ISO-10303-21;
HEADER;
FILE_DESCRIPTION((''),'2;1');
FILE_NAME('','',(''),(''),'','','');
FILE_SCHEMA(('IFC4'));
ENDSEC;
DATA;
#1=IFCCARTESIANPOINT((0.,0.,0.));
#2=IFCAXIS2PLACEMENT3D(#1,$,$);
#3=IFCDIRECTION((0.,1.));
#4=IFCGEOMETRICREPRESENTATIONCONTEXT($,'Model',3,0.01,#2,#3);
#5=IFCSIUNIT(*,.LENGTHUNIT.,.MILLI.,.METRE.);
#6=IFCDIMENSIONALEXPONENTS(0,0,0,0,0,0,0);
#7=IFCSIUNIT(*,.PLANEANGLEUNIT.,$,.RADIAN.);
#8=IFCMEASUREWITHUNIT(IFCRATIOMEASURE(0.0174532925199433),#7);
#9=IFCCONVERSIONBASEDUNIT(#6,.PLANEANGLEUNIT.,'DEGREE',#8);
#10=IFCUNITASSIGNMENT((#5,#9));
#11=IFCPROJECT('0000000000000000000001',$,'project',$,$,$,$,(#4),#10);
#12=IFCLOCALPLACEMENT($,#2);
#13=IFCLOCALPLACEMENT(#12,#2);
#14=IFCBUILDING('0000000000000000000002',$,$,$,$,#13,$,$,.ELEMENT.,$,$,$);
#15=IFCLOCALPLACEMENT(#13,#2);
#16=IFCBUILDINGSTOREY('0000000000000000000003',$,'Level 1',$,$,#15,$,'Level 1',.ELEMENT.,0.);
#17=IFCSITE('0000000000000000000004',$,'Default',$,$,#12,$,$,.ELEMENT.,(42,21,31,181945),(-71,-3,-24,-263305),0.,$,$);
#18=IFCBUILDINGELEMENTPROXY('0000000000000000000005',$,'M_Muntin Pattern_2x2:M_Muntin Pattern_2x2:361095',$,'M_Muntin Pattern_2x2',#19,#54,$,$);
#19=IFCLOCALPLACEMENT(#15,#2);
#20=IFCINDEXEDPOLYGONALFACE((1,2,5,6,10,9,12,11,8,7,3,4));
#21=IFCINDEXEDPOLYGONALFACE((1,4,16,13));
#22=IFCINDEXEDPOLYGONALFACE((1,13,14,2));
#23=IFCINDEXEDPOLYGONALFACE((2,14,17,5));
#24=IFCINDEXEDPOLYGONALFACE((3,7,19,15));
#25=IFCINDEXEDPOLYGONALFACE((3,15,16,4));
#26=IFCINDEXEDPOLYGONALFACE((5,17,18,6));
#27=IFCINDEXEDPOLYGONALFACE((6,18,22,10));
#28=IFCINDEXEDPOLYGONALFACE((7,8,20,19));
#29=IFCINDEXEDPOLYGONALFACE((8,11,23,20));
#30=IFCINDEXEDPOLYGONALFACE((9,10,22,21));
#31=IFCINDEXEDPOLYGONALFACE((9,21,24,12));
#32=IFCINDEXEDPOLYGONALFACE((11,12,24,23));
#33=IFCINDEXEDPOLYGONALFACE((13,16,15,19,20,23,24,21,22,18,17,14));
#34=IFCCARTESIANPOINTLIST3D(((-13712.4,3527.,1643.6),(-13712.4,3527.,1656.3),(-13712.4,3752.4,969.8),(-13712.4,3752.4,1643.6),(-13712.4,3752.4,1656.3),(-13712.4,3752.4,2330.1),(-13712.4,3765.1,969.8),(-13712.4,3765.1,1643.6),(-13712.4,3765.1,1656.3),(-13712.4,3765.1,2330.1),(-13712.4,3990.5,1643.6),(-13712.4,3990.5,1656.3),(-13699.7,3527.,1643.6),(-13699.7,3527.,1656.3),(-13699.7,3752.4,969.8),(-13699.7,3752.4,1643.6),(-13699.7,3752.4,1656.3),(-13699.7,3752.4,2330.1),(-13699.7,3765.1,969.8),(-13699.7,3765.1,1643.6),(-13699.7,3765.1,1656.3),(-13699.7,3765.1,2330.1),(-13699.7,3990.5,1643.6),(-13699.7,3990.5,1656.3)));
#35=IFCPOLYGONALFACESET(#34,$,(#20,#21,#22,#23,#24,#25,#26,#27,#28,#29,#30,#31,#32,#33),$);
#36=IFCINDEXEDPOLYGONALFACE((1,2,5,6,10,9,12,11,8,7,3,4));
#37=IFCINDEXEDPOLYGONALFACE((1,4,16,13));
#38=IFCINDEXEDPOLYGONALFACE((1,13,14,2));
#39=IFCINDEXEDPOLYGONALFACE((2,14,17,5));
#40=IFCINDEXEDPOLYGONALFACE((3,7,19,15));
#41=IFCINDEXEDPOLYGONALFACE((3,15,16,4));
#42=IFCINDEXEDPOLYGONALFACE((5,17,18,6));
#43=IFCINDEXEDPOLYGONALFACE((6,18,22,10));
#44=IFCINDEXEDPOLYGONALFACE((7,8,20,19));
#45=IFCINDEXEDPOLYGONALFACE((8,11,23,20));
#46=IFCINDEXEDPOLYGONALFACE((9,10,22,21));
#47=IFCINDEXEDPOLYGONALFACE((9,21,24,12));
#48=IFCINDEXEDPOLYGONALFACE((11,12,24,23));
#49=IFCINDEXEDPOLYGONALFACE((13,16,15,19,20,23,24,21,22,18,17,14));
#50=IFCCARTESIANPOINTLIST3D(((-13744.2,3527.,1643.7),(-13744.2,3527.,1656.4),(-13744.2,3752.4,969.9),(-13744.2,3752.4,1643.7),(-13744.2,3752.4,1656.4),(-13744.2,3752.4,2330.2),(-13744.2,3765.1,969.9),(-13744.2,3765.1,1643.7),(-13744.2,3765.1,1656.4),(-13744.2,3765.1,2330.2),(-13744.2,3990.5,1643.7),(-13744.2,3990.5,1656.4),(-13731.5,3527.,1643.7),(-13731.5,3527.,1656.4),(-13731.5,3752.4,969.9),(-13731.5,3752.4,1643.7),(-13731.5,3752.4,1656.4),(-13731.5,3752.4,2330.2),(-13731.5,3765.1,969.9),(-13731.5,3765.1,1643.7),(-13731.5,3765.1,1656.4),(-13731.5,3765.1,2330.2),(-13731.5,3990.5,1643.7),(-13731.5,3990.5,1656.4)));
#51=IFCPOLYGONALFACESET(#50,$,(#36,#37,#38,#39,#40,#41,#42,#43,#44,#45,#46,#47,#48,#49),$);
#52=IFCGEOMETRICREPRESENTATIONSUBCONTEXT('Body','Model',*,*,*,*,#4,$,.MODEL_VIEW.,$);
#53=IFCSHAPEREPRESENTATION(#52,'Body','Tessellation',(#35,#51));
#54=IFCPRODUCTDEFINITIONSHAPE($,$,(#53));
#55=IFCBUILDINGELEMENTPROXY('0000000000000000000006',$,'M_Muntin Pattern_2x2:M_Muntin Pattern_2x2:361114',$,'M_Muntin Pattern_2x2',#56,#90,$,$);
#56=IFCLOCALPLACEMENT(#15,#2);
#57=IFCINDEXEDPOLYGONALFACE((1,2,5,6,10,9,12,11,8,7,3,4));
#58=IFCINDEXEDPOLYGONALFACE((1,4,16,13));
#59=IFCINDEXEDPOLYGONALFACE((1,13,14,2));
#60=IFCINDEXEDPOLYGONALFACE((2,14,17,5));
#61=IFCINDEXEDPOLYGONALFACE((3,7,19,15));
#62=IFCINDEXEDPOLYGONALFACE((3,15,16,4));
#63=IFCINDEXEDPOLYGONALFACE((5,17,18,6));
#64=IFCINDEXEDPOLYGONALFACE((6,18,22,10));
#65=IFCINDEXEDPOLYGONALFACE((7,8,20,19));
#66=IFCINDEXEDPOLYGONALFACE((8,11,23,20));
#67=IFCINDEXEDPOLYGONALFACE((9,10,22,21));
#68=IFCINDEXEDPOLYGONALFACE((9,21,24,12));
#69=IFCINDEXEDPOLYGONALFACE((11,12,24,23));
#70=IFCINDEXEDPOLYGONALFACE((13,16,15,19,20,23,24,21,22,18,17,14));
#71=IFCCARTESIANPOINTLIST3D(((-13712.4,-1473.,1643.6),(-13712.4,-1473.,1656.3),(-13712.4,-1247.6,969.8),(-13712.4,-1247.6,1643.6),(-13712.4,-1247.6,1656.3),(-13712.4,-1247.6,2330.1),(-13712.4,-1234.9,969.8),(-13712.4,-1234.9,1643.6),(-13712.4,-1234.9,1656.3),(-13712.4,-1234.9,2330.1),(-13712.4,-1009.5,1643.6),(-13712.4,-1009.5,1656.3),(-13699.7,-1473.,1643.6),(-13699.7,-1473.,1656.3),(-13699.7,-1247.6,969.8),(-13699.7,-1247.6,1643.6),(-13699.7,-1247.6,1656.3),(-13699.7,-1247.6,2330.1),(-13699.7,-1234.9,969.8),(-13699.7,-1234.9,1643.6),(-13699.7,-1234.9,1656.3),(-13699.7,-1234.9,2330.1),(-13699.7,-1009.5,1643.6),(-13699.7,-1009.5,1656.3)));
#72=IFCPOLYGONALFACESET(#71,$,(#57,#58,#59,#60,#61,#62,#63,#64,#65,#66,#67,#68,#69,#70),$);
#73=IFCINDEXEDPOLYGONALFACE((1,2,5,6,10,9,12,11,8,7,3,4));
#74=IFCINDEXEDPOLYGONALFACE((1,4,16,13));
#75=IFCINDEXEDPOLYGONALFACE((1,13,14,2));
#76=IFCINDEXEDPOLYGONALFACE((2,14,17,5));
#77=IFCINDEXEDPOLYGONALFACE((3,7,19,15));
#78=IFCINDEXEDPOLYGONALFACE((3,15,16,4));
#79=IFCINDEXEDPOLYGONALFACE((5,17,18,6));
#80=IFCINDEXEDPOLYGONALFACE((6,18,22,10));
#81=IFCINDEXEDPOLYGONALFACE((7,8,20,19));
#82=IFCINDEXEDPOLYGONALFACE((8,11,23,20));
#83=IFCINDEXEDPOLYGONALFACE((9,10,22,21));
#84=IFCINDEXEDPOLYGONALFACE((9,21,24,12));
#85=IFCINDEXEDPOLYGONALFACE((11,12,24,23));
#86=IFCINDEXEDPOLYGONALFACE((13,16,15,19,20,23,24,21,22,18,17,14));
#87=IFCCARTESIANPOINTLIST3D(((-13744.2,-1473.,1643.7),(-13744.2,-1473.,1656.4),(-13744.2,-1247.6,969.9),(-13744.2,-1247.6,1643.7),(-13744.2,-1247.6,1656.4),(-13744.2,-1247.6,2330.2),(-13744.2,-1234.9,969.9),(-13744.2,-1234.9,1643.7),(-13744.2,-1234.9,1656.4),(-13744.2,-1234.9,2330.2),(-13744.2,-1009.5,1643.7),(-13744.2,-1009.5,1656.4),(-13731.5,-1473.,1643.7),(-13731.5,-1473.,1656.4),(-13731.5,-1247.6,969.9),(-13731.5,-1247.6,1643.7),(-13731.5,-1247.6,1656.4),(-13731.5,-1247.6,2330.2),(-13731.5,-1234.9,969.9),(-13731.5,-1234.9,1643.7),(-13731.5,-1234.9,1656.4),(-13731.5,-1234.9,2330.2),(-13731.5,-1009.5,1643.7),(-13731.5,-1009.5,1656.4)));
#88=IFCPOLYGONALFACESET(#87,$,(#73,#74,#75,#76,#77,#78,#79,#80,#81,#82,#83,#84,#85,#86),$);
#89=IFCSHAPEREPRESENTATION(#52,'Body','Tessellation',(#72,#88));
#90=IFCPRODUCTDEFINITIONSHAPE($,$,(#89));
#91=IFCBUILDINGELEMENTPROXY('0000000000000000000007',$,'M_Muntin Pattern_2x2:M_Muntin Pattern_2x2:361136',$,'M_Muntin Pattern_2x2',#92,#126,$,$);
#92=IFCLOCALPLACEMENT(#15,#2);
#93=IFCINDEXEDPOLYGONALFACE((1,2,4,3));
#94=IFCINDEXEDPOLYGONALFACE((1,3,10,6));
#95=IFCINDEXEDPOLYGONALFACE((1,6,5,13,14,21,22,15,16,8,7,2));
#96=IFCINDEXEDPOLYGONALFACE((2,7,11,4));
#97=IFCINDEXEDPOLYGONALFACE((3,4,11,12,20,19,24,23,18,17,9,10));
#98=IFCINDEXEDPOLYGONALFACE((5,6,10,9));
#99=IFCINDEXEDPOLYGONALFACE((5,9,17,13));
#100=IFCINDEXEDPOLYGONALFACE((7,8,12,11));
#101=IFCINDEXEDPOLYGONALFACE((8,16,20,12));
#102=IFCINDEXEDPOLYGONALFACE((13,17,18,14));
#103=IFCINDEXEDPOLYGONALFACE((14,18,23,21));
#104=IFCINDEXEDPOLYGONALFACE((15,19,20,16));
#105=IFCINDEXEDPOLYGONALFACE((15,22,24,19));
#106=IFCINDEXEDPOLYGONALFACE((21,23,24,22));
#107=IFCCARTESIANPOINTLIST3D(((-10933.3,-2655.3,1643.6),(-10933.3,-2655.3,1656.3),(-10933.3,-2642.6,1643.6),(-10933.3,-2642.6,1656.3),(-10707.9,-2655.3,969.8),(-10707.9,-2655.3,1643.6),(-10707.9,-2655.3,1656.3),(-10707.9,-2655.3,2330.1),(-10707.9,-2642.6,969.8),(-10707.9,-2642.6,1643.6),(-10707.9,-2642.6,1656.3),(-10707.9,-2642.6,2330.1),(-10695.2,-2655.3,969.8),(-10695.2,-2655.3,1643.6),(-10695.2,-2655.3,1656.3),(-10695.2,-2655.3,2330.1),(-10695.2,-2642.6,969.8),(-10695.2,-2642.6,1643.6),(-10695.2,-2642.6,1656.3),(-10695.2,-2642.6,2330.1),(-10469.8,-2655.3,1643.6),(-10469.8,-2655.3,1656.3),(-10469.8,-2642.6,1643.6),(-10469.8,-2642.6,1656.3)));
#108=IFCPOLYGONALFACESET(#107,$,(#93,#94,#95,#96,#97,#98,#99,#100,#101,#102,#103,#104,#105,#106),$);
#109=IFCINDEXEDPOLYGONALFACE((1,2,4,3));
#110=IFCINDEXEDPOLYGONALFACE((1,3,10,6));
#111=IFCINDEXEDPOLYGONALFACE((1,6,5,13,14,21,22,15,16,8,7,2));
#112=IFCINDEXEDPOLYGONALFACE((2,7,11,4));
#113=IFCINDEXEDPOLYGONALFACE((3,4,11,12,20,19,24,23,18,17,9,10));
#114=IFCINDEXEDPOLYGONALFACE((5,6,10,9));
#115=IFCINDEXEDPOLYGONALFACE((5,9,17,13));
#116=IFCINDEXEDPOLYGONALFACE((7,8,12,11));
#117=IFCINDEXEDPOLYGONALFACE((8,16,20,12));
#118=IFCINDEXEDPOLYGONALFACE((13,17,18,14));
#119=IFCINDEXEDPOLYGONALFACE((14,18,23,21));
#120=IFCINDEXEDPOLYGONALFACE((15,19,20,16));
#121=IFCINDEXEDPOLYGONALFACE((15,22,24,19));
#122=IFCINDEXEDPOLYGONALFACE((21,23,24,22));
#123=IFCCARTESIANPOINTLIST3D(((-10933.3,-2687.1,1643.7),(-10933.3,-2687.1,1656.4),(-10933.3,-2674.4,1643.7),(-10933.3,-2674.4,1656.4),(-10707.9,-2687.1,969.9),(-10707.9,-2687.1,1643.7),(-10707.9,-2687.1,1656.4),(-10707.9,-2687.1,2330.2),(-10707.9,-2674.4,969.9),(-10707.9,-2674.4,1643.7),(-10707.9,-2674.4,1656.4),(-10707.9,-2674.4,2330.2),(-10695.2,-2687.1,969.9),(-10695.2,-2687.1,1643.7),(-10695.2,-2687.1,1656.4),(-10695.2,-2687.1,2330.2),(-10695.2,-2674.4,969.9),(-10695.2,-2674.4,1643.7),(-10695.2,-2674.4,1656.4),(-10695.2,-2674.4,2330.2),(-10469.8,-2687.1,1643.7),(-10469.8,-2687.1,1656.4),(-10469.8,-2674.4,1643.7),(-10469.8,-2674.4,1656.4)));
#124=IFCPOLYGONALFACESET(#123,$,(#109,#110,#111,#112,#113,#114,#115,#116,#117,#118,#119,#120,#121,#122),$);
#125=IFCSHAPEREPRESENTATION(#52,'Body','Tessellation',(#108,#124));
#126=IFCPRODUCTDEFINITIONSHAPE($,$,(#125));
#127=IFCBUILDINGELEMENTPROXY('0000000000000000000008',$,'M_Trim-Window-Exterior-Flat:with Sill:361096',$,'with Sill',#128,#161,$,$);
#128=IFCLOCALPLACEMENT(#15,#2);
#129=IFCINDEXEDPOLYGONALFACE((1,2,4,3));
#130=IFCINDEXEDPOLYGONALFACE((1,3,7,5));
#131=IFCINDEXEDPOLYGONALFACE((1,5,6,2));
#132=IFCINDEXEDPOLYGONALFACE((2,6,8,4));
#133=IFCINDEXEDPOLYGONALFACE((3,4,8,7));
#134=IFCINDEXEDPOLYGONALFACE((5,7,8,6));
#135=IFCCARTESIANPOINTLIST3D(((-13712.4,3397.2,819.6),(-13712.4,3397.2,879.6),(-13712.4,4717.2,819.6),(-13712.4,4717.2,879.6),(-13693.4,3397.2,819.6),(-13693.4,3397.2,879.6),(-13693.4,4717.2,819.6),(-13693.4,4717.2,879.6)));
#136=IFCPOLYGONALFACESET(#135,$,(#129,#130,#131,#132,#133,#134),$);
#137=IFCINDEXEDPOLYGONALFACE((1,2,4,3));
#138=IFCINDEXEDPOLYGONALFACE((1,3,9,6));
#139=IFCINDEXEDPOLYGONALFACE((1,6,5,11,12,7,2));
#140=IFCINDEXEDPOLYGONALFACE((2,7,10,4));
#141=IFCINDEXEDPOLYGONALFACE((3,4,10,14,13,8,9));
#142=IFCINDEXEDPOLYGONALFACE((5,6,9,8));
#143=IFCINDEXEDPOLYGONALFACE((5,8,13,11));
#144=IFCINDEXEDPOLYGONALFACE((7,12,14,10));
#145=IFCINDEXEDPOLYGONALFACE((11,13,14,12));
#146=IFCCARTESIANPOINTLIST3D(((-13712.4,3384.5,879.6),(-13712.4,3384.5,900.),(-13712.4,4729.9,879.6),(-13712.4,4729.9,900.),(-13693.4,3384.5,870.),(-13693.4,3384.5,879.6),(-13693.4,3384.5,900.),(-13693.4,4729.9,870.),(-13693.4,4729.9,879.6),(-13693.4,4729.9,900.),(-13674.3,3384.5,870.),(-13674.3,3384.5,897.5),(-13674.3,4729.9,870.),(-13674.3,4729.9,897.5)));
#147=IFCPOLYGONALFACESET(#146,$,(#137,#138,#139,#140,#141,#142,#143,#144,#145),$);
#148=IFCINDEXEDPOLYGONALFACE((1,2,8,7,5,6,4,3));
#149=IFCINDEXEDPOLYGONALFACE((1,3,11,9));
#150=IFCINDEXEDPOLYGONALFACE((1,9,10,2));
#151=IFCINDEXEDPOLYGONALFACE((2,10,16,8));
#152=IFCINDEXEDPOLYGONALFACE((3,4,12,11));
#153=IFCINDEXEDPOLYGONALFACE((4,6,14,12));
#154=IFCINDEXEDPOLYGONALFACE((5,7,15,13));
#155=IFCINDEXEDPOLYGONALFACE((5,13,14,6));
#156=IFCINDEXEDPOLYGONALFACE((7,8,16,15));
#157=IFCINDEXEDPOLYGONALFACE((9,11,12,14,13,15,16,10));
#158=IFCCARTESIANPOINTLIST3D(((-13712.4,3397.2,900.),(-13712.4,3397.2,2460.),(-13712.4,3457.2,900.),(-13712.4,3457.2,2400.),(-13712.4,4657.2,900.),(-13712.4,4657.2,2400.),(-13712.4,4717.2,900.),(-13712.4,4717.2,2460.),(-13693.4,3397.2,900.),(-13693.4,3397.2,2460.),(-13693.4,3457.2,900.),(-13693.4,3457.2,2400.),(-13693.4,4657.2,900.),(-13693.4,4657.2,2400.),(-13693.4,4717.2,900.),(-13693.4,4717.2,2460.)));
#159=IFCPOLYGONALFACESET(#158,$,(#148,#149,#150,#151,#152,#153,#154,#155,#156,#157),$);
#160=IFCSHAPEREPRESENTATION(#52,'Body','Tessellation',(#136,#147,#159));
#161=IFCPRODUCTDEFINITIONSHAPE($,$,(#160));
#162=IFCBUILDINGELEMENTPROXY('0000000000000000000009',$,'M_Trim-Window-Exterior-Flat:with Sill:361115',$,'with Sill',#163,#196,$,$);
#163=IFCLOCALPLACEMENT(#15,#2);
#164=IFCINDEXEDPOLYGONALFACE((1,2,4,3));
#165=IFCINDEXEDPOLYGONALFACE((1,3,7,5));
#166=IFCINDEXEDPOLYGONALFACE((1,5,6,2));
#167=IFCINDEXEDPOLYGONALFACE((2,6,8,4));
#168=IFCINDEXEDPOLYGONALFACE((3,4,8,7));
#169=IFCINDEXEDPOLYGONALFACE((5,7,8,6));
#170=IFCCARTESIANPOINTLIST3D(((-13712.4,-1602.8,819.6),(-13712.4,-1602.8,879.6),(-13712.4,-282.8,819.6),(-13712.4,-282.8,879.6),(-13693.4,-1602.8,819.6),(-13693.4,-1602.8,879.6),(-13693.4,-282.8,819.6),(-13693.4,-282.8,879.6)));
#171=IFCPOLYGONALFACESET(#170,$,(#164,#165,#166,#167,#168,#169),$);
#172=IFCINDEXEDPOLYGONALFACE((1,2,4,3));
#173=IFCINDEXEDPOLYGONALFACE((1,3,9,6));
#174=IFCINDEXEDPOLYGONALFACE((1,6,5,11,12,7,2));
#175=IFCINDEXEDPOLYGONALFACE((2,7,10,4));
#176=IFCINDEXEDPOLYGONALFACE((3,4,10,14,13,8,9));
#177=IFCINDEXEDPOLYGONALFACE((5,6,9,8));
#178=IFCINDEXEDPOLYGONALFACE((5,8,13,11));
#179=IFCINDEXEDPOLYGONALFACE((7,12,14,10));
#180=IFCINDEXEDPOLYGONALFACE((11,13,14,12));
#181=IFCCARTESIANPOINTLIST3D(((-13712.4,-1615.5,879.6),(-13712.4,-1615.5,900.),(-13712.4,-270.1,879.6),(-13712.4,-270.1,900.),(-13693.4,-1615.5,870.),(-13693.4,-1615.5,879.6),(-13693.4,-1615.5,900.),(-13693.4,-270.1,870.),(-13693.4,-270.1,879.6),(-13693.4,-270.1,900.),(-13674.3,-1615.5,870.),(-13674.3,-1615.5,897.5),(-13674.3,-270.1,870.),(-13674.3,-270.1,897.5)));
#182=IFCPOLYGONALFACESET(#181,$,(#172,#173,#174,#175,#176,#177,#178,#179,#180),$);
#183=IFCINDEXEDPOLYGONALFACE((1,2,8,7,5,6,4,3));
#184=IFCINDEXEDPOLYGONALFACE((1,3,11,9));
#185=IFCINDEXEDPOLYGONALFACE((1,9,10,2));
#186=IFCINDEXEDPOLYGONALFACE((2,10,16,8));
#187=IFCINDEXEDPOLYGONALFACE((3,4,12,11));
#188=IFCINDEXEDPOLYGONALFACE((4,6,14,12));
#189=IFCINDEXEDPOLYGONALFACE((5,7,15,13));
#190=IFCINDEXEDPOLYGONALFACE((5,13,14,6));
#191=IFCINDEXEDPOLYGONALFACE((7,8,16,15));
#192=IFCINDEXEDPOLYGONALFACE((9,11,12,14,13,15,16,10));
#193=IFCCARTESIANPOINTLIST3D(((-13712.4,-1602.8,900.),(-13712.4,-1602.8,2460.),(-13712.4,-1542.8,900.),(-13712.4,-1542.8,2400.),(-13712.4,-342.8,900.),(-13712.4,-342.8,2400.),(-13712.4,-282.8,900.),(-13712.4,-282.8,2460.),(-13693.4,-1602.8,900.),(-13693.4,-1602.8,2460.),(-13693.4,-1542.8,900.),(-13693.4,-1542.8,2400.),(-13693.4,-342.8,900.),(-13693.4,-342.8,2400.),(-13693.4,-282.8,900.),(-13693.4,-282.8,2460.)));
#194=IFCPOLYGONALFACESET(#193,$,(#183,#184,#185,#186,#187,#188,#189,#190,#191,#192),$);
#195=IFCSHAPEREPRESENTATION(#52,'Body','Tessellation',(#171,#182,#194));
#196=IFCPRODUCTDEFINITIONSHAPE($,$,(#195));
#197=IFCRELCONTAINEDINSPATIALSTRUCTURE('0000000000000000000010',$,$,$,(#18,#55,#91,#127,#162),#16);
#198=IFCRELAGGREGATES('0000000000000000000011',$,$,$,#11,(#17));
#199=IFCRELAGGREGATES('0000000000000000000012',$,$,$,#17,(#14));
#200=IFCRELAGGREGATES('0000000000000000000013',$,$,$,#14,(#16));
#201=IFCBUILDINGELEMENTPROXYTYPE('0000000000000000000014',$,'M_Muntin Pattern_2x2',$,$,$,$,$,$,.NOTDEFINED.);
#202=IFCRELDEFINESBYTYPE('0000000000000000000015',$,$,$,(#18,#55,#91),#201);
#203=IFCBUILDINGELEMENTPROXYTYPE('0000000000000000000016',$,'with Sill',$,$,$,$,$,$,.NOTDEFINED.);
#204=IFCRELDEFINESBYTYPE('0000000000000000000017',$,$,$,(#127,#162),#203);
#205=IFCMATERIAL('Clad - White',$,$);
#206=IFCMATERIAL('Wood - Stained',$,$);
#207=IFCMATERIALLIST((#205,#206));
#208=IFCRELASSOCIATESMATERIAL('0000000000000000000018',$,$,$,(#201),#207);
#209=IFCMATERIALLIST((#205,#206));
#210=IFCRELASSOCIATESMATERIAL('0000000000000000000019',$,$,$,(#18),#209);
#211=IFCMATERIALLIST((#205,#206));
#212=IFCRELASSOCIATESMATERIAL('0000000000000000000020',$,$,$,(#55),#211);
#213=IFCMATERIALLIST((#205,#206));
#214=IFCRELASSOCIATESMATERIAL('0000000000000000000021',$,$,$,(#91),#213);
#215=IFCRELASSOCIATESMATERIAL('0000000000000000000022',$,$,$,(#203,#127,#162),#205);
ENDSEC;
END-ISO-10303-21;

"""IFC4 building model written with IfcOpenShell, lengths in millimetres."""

from ifc_helpers import new_model, entity, si_unit, converted_unit, direction, frame, frame_2d, origin, place, context, subcontext, project, spatial, polyline, rectangle, outline, extrude, source, transform, mapped, material, material_list, type_object, type_shapes, element, save


model = new_model("IFC4")

# Units and contexts
model_context = context("Model", 3, precision=0.01, world=origin(), true_north=direction((0.0, 1.0)))
body_context = subcontext(model_context, "Body", "Model", "MODEL_VIEW")
ifc_project = project(units=[si_unit("LENGTHUNIT", "METRE", prefix="MILLI"), converted_unit("PLANEANGLEUNIT", "DEGREE", entity("IfcRatioMeasure", 0.0174532925199433), si_unit("PLANEANGLEUNIT", "RADIAN"), dimensions=[0, 0, 0, 0, 0, 0, 0])], contexts=[model_context])

# Site, building, storey
site_placement = place(None, origin())
site = spatial("IfcSite", under=ifc_project, at=site_placement, Name="Default", CompositionType="ELEMENT", RefLatitude=(42, 21, 31, 181945), RefLongitude=(-71, -3, -24, -263305), RefElevation=0.0)
building_placement = place(site_placement, origin())
building = spatial("IfcBuilding", under=site, at=building_placement, CompositionType="ELEMENT")
storey_placement = place(building_placement, origin())
storey = spatial("IfcBuildingStorey", under=building, at=storey_placement, Name="Level 1", LongName="Level 1", CompositionType="ELEMENT", Elevation=0.0)

# Building element proxies
ifc_material_1 = material(Name="Clad - White")
ifc_material_2 = material(Name="Wood - Stained")
ifc_material_list_1 = material_list([ifc_material_1, ifc_material_2])
ifc_material_list_2 = material_list([ifc_material_1, ifc_material_2])
building_element_proxy_type_1 = type_object("IfcBuildingElementProxyType", Name="M_Muntin Pattern_2x2", PredefinedType="NOTDEFINED", material=ifc_material_list_2)
shared_shape_1 = source(origin(), body_context, "Body", "SweptSolid", [
    extrude(outline(polyline([(6.4, -6.4), (680.1, -6.4), (680.1, 6.3), (6.4, 6.3), (6.4, 231.7), (-6.3, 231.7), (-6.3, 6.3), (-680.2, 6.3), (-680.2, -6.4), (-6.3, -6.4), (-6.3, -231.7), (6.4, -231.7), (6.4, -6.4)])), frame((0.0, -22.2, 680.1), z_axis=(0.0, 1.0, 0.0), x_axis=(0.0, 0.0, 1.0)), (0.0, 0.0, 1.0), 12.7),
    extrude(outline(polyline([(6.4, -6.4), (680.1, -6.4), (680.1, 6.3), (6.4, 6.3), (6.4, 231.7), (-6.3, 231.7), (-6.3, 6.3), (-680.2, 6.3), (-680.2, -6.4), (-6.3, -6.4), (-6.3, -231.7), (6.4, -231.7), (6.4, -6.4)])), frame((0.0, 9.5, 680.2), z_axis=(0.0, 1.0, 0.0), x_axis=(0.0, 0.0, 1.0)), (0.0, 0.0, 1.0), 12.7),
])
type_shapes(building_element_proxy_type_1, [shared_shape_1])
proxy_1_placement = place(storey_placement, frame((-13722.0, 3758.7, 969.9), z_axis=(0.0, 0.0, 1.0), x_axis=(0.0, 1.0, 0.0)))
element("IfcBuildingElementProxy", 1, at=proxy_1_placement, inside=storey, type_object=building_element_proxy_type_1, material=ifc_material_list_1, Name="M_Muntin Pattern_2x2:M_Muntin Pattern_2x2:361095", ObjectType="M_Muntin Pattern_2x2", context=body_context, shape_type="MappedRepresentation", body=[
    mapped(shared_shape_1, transform((0.0, 0.0, 0.0), scale=1.0)),
])
ifc_material_list_3 = material_list([ifc_material_1, ifc_material_2])
proxy_2_placement = place(storey_placement, frame((-13722.0, -1241.3, 969.9), z_axis=(0.0, 0.0, 1.0), x_axis=(0.0, 1.0, 0.0)))
element("IfcBuildingElementProxy", 2, at=proxy_2_placement, inside=storey, type_object=building_element_proxy_type_1, material=ifc_material_list_3, Name="M_Muntin Pattern_2x2:M_Muntin Pattern_2x2:361114", ObjectType="M_Muntin Pattern_2x2", context=body_context, shape_type="MappedRepresentation", body=[
    mapped(shared_shape_1, transform((0.0, 0.0, 0.0), scale=1.0)),
])
ifc_material_list_4 = material_list([ifc_material_1, ifc_material_2])
proxy_3_placement = place(storey_placement, frame((-10701.5, -2664.9, 969.9), z_axis=(0.0, 0.0, 1.0), x_axis=(-1.0, 0.0, 0.0)))
element("IfcBuildingElementProxy", 3, at=proxy_3_placement, inside=storey, type_object=building_element_proxy_type_1, material=ifc_material_list_4, Name="M_Muntin Pattern_2x2:M_Muntin Pattern_2x2:361136", ObjectType="M_Muntin Pattern_2x2", context=body_context, shape_type="MappedRepresentation", body=[
    mapped(shared_shape_1, transform((0.0, 0.0, 0.0), scale=1.0)),
])
building_element_proxy_type_2 = type_object("IfcBuildingElementProxyType", Name="with Sill", PredefinedType="NOTDEFINED", material=ifc_material_1)
shared_shape_2 = source(origin(), body_context, "Body", "SweptSolid", [
    extrude(rectangle(XDim=1320.0, YDim=60.0, at=frame_2d((0.0, 0.0), x_axis=(1.0, 0.0))), frame((0.0, -1550.4, 0.0), z_axis=(0.0, 0.0, 1.0), x_axis=(-1.0, 0.0, 0.0)), (0.0, 0.0, 1.0), 19.1),
    extrude(outline(polyline([(-19.0, -15.2), (0.0, -15.2), (0.0, -5.7), (19.0, -5.7), (19.0, 14.8), (0.0, 14.8), (-19.0, 12.3), (-19.0, -15.2)])), frame((-672.7, -1514.8, 19.0), z_axis=(1.0, 0.0, 0.0), x_axis=(0.0, 0.0, -1.0)), (0.0, 0.0, 1.0), 1345.4),
    extrude(outline(polyline([(-795.0, -660.0), (765.0, -660.0), (765.0, -600.0), (-735.0, -600.0), (-735.0, 600.0), (765.0, 600.0), (765.0, 660.0), (-795.0, 660.0), (-795.0, -660.0)])), frame((0.0, -735.0, 0.0), z_axis=(0.0, 0.0, 1.0), x_axis=(0.0, -1.0, 0.0)), (0.0, 0.0, 1.0), 19.1),
])
type_shapes(building_element_proxy_type_2, [shared_shape_2])
for number, where, z_axis, x_axis, name in (
    (4, (-13712.4, 4057.2, 2400.0), (1.0, 0.0, 0.0), (0.0, 1.0, 0.0), "M_Trim-Window-Exterior-Flat:with Sill:361096"),
    (5, (-13712.4, -942.8, 2400.0), (1.0, 0.0, 0.0), (0.0, 1.0, 0.0), "M_Trim-Window-Exterior-Flat:with Sill:361115"),
):
    element("IfcBuildingElementProxy", number, at=place(storey_placement, frame(where, z_axis=z_axis, x_axis=x_axis)), inside=storey, type_object=building_element_proxy_type_2, material=ifc_material_1, Name=name, ObjectType="with Sill", context=body_context, shape_type="MappedRepresentation", body=[
        mapped(shared_shape_2, transform((0.0, 0.0, 0.0), scale=1.0)),
    ])

save(model, "model.ifc")
